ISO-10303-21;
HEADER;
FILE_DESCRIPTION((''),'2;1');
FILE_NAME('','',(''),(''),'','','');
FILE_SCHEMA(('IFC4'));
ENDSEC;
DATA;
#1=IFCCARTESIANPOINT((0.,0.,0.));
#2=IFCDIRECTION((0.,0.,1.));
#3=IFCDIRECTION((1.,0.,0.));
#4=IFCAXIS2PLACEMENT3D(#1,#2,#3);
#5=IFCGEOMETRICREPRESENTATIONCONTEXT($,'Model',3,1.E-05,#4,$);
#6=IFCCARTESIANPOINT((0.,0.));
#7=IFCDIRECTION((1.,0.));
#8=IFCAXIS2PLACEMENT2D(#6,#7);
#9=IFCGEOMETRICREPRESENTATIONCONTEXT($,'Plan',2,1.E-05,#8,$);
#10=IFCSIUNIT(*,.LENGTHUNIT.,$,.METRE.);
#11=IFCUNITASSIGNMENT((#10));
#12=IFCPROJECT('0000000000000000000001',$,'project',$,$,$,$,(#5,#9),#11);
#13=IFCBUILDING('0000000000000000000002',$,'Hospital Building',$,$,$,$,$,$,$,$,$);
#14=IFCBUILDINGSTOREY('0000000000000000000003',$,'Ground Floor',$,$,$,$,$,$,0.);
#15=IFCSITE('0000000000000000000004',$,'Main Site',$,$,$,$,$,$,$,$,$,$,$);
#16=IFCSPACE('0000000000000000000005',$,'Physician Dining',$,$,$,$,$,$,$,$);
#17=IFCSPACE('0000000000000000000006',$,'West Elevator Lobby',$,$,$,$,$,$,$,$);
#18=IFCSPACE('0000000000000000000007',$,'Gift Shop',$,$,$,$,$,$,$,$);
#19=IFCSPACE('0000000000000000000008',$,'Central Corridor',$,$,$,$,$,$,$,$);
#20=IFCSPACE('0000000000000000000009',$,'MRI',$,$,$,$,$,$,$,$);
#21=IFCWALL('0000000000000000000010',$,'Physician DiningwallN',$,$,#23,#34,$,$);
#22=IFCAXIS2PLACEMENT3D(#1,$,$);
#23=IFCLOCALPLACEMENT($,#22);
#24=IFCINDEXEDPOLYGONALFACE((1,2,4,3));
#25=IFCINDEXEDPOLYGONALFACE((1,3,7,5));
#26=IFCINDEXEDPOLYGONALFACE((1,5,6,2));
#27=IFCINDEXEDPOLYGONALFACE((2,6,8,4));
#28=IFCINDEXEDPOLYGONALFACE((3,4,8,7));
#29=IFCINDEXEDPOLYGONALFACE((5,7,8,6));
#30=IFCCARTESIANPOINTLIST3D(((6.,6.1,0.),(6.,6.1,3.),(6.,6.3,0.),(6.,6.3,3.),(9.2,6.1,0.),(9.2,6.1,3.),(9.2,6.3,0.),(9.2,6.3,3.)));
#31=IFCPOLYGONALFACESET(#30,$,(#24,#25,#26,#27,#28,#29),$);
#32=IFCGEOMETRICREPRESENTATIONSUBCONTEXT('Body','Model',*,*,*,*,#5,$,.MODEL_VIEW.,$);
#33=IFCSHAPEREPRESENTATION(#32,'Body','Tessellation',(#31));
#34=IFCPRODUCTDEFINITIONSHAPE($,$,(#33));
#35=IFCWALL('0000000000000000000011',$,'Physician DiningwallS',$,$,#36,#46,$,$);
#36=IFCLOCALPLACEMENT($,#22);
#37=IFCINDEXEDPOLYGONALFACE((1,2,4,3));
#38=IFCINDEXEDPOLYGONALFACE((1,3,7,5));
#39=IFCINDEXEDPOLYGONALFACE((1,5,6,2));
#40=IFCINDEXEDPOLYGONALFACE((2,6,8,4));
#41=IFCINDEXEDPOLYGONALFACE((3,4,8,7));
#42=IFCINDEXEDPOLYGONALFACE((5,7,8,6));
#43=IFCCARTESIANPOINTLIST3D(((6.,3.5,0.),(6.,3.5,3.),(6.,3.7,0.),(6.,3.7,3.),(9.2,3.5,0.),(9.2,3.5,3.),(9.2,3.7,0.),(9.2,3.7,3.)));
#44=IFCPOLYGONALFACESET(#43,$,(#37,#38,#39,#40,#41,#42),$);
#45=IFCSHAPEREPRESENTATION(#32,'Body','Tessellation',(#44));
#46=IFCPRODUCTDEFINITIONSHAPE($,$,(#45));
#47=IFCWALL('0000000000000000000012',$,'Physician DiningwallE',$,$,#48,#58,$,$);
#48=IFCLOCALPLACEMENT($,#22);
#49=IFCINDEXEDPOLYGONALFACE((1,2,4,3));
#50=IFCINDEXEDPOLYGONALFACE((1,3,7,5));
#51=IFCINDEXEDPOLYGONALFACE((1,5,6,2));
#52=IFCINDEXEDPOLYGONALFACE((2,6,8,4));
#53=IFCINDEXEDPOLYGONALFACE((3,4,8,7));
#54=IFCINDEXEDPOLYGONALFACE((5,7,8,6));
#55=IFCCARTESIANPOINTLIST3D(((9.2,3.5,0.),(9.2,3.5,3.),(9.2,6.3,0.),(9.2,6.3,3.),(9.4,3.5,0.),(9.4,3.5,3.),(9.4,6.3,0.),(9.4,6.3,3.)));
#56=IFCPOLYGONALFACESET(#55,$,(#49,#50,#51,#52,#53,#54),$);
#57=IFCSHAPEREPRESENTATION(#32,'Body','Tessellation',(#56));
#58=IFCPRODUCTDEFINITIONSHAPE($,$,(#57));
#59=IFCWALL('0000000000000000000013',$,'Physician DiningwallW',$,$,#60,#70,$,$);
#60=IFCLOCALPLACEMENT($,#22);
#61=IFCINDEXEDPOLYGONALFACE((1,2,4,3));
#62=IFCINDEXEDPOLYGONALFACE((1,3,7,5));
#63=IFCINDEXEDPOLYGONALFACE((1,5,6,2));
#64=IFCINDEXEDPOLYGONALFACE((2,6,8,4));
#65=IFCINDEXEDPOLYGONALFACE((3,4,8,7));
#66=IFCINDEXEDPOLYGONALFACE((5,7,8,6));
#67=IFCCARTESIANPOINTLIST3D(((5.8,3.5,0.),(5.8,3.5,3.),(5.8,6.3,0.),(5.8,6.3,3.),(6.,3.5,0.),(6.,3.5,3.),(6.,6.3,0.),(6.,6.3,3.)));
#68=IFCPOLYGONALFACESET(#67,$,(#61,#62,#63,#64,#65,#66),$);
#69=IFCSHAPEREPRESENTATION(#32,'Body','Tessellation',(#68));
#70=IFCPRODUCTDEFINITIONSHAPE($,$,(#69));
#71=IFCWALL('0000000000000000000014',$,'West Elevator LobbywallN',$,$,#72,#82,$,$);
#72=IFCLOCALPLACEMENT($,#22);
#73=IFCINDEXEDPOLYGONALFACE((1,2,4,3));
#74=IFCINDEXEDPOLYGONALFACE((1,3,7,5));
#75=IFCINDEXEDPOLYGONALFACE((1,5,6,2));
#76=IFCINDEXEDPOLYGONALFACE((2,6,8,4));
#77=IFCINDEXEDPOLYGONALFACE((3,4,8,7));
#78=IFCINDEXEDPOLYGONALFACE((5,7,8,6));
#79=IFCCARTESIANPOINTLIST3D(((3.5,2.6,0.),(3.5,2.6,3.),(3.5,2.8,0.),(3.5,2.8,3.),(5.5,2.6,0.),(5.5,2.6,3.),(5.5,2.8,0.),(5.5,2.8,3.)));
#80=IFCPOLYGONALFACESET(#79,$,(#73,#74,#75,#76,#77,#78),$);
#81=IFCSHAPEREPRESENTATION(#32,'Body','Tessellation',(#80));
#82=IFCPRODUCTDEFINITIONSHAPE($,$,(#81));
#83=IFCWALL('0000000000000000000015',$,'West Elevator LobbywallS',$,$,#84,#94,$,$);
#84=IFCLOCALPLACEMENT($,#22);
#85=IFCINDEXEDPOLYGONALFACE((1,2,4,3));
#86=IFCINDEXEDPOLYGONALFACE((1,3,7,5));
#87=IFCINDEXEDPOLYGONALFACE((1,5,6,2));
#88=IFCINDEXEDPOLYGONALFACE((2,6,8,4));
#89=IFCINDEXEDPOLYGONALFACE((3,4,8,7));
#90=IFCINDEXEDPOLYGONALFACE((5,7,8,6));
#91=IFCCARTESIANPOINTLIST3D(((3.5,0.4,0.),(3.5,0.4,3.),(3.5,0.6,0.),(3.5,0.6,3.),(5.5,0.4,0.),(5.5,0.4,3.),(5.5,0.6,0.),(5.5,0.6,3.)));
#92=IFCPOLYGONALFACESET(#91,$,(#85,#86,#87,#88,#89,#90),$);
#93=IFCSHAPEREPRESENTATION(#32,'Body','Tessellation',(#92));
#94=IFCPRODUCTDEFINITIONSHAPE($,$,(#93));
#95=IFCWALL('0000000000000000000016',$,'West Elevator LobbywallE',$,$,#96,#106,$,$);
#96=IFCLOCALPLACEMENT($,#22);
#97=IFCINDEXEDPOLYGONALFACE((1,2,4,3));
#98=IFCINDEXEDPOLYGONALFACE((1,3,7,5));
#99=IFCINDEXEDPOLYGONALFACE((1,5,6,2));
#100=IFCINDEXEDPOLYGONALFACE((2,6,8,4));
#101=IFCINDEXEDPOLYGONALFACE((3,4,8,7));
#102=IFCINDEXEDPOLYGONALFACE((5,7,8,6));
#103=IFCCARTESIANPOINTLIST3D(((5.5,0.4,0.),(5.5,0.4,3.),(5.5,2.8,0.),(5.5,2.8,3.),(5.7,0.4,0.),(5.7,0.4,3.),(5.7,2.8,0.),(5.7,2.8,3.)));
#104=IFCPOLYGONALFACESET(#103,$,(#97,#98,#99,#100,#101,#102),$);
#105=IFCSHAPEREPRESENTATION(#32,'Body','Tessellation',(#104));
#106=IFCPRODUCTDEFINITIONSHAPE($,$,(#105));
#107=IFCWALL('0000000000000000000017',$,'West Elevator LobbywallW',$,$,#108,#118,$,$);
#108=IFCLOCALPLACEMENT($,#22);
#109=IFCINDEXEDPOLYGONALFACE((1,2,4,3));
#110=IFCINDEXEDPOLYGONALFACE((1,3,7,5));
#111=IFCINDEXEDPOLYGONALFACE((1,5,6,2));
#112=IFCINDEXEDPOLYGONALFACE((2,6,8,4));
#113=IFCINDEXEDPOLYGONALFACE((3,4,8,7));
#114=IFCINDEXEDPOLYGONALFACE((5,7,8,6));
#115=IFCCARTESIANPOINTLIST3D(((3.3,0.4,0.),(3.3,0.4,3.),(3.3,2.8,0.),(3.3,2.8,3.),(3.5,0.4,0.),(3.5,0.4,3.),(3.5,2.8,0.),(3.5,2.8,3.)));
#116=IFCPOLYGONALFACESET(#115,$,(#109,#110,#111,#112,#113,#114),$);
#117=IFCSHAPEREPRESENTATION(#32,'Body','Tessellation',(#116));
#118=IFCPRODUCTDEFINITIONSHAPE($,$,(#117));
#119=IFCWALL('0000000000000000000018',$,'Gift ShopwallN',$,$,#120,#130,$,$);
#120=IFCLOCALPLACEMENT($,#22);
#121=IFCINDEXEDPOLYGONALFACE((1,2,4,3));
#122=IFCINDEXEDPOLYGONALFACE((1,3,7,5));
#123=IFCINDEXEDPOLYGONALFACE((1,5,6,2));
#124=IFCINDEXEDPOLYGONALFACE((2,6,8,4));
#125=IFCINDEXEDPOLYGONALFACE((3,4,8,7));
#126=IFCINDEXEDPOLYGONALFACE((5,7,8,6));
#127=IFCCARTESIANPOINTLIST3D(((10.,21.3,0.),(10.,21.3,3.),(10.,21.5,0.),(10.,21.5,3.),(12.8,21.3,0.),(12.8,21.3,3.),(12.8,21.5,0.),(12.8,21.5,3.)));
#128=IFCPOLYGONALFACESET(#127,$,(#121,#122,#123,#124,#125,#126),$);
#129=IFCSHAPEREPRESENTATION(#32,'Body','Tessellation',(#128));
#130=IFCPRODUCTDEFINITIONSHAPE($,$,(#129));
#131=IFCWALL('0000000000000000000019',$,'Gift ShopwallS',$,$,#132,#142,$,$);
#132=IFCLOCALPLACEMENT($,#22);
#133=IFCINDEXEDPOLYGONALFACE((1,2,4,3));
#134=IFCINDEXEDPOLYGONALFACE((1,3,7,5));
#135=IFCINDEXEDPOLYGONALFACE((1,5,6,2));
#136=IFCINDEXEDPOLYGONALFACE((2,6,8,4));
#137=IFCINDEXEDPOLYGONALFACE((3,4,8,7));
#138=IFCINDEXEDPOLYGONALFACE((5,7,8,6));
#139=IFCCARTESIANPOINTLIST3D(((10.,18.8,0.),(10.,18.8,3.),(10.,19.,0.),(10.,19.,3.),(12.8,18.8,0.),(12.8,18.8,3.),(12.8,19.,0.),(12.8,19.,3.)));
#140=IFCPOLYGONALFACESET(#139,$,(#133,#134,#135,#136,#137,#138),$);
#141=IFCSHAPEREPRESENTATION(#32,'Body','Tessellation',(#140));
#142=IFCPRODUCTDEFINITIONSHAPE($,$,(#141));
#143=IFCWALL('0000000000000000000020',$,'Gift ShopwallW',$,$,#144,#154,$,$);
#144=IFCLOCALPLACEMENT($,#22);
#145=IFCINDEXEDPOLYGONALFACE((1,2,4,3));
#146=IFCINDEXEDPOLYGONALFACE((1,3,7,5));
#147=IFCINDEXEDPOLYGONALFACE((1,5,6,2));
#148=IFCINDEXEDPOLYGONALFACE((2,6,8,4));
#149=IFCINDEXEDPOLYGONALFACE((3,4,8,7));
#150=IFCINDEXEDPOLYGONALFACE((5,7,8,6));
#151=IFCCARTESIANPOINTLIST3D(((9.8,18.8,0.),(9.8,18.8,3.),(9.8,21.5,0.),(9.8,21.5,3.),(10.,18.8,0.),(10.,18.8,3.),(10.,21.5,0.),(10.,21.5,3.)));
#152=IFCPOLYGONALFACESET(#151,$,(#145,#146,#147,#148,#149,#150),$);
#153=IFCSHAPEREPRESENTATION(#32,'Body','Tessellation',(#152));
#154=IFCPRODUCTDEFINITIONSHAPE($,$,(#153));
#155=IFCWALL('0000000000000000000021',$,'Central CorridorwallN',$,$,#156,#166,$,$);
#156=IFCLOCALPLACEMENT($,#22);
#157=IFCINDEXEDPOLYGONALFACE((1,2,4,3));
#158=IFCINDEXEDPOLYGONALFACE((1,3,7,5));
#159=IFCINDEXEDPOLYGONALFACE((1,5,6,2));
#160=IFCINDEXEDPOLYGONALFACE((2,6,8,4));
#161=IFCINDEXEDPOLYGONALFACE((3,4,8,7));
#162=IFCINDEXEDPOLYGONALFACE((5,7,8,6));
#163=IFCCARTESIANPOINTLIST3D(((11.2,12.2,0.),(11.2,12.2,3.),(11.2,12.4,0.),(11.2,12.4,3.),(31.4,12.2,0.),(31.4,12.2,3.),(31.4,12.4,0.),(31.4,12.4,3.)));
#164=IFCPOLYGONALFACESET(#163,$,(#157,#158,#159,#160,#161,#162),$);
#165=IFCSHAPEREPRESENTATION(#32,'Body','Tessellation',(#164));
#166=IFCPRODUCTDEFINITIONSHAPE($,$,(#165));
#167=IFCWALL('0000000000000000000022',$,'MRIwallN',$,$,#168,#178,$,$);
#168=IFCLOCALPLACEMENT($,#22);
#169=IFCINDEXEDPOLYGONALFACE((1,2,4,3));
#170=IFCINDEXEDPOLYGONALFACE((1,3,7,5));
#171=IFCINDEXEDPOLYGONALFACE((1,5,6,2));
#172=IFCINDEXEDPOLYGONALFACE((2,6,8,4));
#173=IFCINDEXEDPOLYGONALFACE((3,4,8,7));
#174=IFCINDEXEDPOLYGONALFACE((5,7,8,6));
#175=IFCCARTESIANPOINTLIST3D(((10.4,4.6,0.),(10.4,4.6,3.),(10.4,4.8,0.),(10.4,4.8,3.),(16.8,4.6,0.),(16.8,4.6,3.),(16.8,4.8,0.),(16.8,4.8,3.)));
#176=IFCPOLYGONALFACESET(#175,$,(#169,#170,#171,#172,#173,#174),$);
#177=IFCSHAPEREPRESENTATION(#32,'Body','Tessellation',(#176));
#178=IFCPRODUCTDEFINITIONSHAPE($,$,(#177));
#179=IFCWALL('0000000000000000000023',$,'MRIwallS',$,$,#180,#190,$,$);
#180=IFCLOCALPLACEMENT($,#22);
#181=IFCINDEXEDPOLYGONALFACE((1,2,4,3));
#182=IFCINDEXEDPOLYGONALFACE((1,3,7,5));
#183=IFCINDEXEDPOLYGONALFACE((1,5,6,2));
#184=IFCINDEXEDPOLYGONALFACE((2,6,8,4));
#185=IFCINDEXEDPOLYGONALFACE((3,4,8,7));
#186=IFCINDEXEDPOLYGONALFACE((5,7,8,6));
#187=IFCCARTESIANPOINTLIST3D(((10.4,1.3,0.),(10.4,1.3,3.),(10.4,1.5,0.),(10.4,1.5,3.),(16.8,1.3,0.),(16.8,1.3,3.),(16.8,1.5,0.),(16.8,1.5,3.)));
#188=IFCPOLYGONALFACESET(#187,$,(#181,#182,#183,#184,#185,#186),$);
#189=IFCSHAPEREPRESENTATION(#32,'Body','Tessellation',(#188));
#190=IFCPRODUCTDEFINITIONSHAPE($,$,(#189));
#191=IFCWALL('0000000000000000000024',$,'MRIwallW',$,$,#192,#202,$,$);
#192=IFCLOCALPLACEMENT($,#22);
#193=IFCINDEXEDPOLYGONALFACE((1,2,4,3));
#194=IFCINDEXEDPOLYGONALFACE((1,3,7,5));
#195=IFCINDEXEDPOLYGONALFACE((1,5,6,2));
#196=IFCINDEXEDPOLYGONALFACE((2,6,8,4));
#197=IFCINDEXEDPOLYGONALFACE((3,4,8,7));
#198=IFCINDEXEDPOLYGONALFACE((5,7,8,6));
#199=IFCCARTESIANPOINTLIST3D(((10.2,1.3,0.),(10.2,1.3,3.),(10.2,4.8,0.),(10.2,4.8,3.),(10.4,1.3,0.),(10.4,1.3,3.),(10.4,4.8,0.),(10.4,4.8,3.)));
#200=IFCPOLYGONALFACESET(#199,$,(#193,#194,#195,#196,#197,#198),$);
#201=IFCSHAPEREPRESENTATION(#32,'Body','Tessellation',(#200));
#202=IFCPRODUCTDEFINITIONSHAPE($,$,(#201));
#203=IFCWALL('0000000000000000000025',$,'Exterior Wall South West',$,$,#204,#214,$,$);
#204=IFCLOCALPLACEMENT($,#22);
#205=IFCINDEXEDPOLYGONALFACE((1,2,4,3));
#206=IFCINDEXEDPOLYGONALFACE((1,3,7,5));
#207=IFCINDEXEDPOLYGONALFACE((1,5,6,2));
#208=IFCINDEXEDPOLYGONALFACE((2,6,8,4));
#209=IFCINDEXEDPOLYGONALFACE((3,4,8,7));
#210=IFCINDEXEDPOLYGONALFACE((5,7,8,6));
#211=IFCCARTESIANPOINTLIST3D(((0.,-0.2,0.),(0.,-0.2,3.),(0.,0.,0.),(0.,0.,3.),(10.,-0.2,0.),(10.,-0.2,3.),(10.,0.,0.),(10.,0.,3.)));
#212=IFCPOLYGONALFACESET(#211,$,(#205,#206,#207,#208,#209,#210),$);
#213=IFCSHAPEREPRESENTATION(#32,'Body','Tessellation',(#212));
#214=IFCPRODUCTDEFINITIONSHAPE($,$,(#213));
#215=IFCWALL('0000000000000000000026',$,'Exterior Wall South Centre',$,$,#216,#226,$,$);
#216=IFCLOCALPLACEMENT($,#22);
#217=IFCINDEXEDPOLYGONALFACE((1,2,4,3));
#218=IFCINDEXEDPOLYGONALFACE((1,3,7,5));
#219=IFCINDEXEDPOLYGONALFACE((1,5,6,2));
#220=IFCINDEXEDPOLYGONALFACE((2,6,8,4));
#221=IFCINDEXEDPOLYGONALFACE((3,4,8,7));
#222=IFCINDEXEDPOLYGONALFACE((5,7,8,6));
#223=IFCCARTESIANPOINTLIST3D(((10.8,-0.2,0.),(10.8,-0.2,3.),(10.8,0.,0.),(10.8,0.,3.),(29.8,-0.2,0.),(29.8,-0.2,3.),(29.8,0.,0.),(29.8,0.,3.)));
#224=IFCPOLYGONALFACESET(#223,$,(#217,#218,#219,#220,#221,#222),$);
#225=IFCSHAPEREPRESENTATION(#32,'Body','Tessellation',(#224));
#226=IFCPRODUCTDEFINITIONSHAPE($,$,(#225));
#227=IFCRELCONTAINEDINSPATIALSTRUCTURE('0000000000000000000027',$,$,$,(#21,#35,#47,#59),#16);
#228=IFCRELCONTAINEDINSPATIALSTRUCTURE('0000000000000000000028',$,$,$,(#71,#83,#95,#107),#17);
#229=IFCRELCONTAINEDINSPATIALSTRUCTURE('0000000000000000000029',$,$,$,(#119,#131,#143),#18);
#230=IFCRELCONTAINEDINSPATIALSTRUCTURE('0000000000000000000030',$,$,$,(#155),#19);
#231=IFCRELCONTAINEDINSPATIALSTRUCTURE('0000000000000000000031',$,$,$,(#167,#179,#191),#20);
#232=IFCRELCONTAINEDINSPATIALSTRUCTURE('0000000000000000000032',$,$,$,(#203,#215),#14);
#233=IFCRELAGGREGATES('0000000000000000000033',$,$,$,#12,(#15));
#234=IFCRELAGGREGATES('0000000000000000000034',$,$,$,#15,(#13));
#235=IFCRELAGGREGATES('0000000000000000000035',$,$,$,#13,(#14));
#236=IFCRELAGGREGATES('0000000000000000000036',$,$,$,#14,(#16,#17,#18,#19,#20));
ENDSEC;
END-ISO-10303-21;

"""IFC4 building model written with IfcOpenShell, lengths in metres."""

from ifc_helpers import new_model, si_unit, frame, origin_with_axes, origin_2d_with_axis, place, context, subcontext, project, spatial, indexed_curve, outline, extrude, element, save


model = new_model("IFC4")

# Units and contexts
model_context = context("Model", 3, precision=1e-05, world=origin_with_axes())
plan_context = context("Plan", 2, precision=1e-05, world=origin_2d_with_axis())
body_context = subcontext(model_context, "Body", "Model", "MODEL_VIEW")
ifc_project = project(units=[si_unit("LENGTHUNIT", "METRE")], contexts=[model_context, plan_context])

# Site, building, storey
site = spatial("IfcSite", under=ifc_project, Name="Main Site")
building = spatial("IfcBuilding", under=site, Name="Hospital Building")
storey = spatial("IfcBuildingStorey", under=building, Name="Ground Floor", Elevation=0.0)

# Shared definitions
space_1 = spatial("IfcSpace", under=storey, Name="Physician Dining")

# Shared definitions
space_2 = spatial("IfcSpace", under=storey, Name="West Elevator Lobby")

# Walls
for number, where, z_axis, x_axis, name in (
    (1, (6.0, 6.1, 0.0), (0.0, 0.0, 1.0), (1.0, 0.0, 0.0), "Physician DiningwallN"),
    (2, (6.0, 3.5, 0.0), (0.0, 0.0, 1.0), (1.0, 0.0, 0.0), "Physician DiningwallS"),
):
    element("IfcWall", number, at=place(None, frame(where, z_axis=z_axis, x_axis=x_axis)), inside=space_1, Name=name, context=body_context, shape_type="SweptSolid", body=[
        extrude(outline(indexed_curve([(0.0, 0.0), (0.0, 0.2), (3.2, 0.2), (3.2, 0.0), (0.0, 0.0)], self_intersect=False)), origin_with_axes(), (0.0, 0.0, 1.0), 3.0),
    ])
for number, where, z_axis, x_axis, name in (
    (3, (9.4, 3.5, 0.0), (0.0, 0.0, 1.0), (0.0, 1.0, 0.0), "Physician DiningwallE"),
    (4, (6.0, 3.5, 0.0), (0.0, 0.0, 1.0), (0.0, 1.0, 0.0), "Physician DiningwallW"),
):
    element("IfcWall", number, at=place(None, frame(where, z_axis=z_axis, x_axis=x_axis)), inside=space_1, Name=name, context=body_context, shape_type="SweptSolid", body=[
        extrude(outline(indexed_curve([(0.0, 0.0), (0.0, 0.2), (2.8, 0.2), (2.8, 0.0), (0.0, 0.0)], self_intersect=False)), origin_with_axes(), (0.0, 0.0, 1.0), 3.0),
    ])
for number, where, z_axis, x_axis, name in (
    (5, (3.5, 2.6, 0.0), (0.0, 0.0, 1.0), (1.0, 0.0, 0.0), "West Elevator LobbywallN"),
    (6, (3.5, 0.4, 0.0), (0.0, 0.0, 1.0), (1.0, 0.0, 0.0), "West Elevator LobbywallS"),
):
    element("IfcWall", number, at=place(None, frame(where, z_axis=z_axis, x_axis=x_axis)), inside=space_2, Name=name, context=body_context, shape_type="SweptSolid", body=[
        extrude(outline(indexed_curve([(0.0, 0.0), (0.0, 0.2), (2.0, 0.2), (2.0, 0.0), (0.0, 0.0)], self_intersect=False)), origin_with_axes(), (0.0, 0.0, 1.0), 3.0),
    ])
for number, where, z_axis, x_axis, name in (
    (7, (5.7, 0.4, 0.0), (0.0, 0.0, 1.0), (0.0, 1.0, 0.0), "West Elevator LobbywallE"),
    (8, (3.5, 0.4, 0.0), (0.0, 0.0, 1.0), (0.0, 1.0, 0.0), "West Elevator LobbywallW"),
):
    element("IfcWall", number, at=place(None, frame(where, z_axis=z_axis, x_axis=x_axis)), inside=space_2, Name=name, context=body_context, shape_type="SweptSolid", body=[
        extrude(outline(indexed_curve([(0.0, 0.0), (0.0, 0.2), (2.4, 0.2), (2.4, 0.0), (0.0, 0.0)], self_intersect=False)), origin_with_axes(), (0.0, 0.0, 1.0), 3.0),
    ])

# Shared definitions
space_3 = spatial("IfcSpace", under=storey, Name="Gift Shop")

# Walls
for number, where, z_axis, x_axis, name in (
    (9, (10.0, 21.3, 0.0), (0.0, 0.0, 1.0), (1.0, 0.0, 0.0), "Gift ShopwallN"),
    (10, (10.0, 18.8, 0.0), (0.0, 0.0, 1.0), (1.0, 0.0, 0.0), "Gift ShopwallS"),
):
    element("IfcWall", number, at=place(None, frame(where, z_axis=z_axis, x_axis=x_axis)), inside=space_3, Name=name, context=body_context, shape_type="SweptSolid", body=[
        extrude(outline(indexed_curve([(0.0, 0.0), (0.0, 0.2), (2.8, 0.2), (2.8, 0.0), (0.0, 0.0)], self_intersect=False)), origin_with_axes(), (0.0, 0.0, 1.0), 3.0),
    ])
wall_1_placement = place(None, frame((10.0, 18.8, 0.0), z_axis=(0.0, 0.0, 1.0), x_axis=(0.0, 1.0, 0.0)))
element("IfcWall", 11, at=wall_1_placement, inside=space_3, Name="Gift ShopwallW", context=body_context, shape_type="SweptSolid", body=[
    extrude(outline(indexed_curve([(0.0, 0.0), (0.0, 0.2), (2.7, 0.2), (2.7, 0.0), (0.0, 0.0)], self_intersect=False)), origin_with_axes(), (0.0, 0.0, 1.0), 3.0),
])

# Shared definitions
space_4 = spatial("IfcSpace", under=storey, Name="Central Corridor")

# Wall
wall_2_placement = place(None, frame((11.2, 12.2, 0.0), z_axis=(0.0, 0.0, 1.0), x_axis=(1.0, 0.0, 0.0)))
element("IfcWall", 12, at=wall_2_placement, inside=space_4, Name="Central CorridorwallN", context=body_context, shape_type="SweptSolid", body=[
    extrude(outline(indexed_curve([(0.0, 0.0), (0.0, 0.2), (20.2, 0.2), (20.2, 0.0), (0.0, 0.0)], self_intersect=False)), origin_with_axes(), (0.0, 0.0, 1.0), 3.0),
])

# Shared definitions
space_5 = spatial("IfcSpace", under=storey, Name="MRI")

# Walls
for number, where, z_axis, x_axis, name in (
    (13, (10.4, 4.6, 0.0), (0.0, 0.0, 1.0), (1.0, 0.0, 0.0), "MRIwallN"),
    (14, (10.4, 1.3, 0.0), (0.0, 0.0, 1.0), (1.0, 0.0, 0.0), "MRIwallS"),
):
    element("IfcWall", number, at=place(None, frame(where, z_axis=z_axis, x_axis=x_axis)), inside=space_5, Name=name, context=body_context, shape_type="SweptSolid", body=[
        extrude(outline(indexed_curve([(0.0, 0.0), (0.0, 0.2), (6.4, 0.2), (6.4, 0.0), (0.0, 0.0)], self_intersect=False)), origin_with_axes(), (0.0, 0.0, 1.0), 3.0),
    ])
wall_3_placement = place(None, frame((10.4, 1.3, 0.0), z_axis=(0.0, 0.0, 1.0), x_axis=(0.0, 1.0, 0.0)))
element("IfcWall", 15, at=wall_3_placement, inside=space_5, Name="MRIwallW", context=body_context, shape_type="SweptSolid", body=[
    extrude(outline(indexed_curve([(0.0, 0.0), (0.0, 0.2), (3.5, 0.2), (3.5, 0.0), (0.0, 0.0)], self_intersect=False)), origin_with_axes(), (0.0, 0.0, 1.0), 3.0),
])
wall_4_placement = place(None, frame((0.0, -0.2, 0.0), z_axis=(0.0, 0.0, 1.0), x_axis=(1.0, 0.0, 0.0)))
element("IfcWall", 16, at=wall_4_placement, inside=storey, Name="Exterior Wall South West", context=body_context, shape_type="SweptSolid", body=[
    extrude(outline(indexed_curve([(0.0, 0.0), (0.0, 0.2), (10.0, 0.2), (10.0, 0.0), (0.0, 0.0)], self_intersect=False)), origin_with_axes(), (0.0, 0.0, 1.0), 3.0),
])
wall_5_placement = place(None, frame((10.8, -0.2, 0.0), z_axis=(0.0, 0.0, 1.0), x_axis=(1.0, 0.0, 0.0)))
element("IfcWall", 17, at=wall_5_placement, inside=storey, Name="Exterior Wall South Centre", context=body_context, shape_type="SweptSolid", body=[
    extrude(outline(indexed_curve([(0.0, 0.0), (0.0, 0.2), (19.0, 0.2), (19.0, 0.0), (0.0, 0.0)], self_intersect=False)), origin_with_axes(), (0.0, 0.0, 1.0), 3.0),
])

save(model, "model.ifc")
